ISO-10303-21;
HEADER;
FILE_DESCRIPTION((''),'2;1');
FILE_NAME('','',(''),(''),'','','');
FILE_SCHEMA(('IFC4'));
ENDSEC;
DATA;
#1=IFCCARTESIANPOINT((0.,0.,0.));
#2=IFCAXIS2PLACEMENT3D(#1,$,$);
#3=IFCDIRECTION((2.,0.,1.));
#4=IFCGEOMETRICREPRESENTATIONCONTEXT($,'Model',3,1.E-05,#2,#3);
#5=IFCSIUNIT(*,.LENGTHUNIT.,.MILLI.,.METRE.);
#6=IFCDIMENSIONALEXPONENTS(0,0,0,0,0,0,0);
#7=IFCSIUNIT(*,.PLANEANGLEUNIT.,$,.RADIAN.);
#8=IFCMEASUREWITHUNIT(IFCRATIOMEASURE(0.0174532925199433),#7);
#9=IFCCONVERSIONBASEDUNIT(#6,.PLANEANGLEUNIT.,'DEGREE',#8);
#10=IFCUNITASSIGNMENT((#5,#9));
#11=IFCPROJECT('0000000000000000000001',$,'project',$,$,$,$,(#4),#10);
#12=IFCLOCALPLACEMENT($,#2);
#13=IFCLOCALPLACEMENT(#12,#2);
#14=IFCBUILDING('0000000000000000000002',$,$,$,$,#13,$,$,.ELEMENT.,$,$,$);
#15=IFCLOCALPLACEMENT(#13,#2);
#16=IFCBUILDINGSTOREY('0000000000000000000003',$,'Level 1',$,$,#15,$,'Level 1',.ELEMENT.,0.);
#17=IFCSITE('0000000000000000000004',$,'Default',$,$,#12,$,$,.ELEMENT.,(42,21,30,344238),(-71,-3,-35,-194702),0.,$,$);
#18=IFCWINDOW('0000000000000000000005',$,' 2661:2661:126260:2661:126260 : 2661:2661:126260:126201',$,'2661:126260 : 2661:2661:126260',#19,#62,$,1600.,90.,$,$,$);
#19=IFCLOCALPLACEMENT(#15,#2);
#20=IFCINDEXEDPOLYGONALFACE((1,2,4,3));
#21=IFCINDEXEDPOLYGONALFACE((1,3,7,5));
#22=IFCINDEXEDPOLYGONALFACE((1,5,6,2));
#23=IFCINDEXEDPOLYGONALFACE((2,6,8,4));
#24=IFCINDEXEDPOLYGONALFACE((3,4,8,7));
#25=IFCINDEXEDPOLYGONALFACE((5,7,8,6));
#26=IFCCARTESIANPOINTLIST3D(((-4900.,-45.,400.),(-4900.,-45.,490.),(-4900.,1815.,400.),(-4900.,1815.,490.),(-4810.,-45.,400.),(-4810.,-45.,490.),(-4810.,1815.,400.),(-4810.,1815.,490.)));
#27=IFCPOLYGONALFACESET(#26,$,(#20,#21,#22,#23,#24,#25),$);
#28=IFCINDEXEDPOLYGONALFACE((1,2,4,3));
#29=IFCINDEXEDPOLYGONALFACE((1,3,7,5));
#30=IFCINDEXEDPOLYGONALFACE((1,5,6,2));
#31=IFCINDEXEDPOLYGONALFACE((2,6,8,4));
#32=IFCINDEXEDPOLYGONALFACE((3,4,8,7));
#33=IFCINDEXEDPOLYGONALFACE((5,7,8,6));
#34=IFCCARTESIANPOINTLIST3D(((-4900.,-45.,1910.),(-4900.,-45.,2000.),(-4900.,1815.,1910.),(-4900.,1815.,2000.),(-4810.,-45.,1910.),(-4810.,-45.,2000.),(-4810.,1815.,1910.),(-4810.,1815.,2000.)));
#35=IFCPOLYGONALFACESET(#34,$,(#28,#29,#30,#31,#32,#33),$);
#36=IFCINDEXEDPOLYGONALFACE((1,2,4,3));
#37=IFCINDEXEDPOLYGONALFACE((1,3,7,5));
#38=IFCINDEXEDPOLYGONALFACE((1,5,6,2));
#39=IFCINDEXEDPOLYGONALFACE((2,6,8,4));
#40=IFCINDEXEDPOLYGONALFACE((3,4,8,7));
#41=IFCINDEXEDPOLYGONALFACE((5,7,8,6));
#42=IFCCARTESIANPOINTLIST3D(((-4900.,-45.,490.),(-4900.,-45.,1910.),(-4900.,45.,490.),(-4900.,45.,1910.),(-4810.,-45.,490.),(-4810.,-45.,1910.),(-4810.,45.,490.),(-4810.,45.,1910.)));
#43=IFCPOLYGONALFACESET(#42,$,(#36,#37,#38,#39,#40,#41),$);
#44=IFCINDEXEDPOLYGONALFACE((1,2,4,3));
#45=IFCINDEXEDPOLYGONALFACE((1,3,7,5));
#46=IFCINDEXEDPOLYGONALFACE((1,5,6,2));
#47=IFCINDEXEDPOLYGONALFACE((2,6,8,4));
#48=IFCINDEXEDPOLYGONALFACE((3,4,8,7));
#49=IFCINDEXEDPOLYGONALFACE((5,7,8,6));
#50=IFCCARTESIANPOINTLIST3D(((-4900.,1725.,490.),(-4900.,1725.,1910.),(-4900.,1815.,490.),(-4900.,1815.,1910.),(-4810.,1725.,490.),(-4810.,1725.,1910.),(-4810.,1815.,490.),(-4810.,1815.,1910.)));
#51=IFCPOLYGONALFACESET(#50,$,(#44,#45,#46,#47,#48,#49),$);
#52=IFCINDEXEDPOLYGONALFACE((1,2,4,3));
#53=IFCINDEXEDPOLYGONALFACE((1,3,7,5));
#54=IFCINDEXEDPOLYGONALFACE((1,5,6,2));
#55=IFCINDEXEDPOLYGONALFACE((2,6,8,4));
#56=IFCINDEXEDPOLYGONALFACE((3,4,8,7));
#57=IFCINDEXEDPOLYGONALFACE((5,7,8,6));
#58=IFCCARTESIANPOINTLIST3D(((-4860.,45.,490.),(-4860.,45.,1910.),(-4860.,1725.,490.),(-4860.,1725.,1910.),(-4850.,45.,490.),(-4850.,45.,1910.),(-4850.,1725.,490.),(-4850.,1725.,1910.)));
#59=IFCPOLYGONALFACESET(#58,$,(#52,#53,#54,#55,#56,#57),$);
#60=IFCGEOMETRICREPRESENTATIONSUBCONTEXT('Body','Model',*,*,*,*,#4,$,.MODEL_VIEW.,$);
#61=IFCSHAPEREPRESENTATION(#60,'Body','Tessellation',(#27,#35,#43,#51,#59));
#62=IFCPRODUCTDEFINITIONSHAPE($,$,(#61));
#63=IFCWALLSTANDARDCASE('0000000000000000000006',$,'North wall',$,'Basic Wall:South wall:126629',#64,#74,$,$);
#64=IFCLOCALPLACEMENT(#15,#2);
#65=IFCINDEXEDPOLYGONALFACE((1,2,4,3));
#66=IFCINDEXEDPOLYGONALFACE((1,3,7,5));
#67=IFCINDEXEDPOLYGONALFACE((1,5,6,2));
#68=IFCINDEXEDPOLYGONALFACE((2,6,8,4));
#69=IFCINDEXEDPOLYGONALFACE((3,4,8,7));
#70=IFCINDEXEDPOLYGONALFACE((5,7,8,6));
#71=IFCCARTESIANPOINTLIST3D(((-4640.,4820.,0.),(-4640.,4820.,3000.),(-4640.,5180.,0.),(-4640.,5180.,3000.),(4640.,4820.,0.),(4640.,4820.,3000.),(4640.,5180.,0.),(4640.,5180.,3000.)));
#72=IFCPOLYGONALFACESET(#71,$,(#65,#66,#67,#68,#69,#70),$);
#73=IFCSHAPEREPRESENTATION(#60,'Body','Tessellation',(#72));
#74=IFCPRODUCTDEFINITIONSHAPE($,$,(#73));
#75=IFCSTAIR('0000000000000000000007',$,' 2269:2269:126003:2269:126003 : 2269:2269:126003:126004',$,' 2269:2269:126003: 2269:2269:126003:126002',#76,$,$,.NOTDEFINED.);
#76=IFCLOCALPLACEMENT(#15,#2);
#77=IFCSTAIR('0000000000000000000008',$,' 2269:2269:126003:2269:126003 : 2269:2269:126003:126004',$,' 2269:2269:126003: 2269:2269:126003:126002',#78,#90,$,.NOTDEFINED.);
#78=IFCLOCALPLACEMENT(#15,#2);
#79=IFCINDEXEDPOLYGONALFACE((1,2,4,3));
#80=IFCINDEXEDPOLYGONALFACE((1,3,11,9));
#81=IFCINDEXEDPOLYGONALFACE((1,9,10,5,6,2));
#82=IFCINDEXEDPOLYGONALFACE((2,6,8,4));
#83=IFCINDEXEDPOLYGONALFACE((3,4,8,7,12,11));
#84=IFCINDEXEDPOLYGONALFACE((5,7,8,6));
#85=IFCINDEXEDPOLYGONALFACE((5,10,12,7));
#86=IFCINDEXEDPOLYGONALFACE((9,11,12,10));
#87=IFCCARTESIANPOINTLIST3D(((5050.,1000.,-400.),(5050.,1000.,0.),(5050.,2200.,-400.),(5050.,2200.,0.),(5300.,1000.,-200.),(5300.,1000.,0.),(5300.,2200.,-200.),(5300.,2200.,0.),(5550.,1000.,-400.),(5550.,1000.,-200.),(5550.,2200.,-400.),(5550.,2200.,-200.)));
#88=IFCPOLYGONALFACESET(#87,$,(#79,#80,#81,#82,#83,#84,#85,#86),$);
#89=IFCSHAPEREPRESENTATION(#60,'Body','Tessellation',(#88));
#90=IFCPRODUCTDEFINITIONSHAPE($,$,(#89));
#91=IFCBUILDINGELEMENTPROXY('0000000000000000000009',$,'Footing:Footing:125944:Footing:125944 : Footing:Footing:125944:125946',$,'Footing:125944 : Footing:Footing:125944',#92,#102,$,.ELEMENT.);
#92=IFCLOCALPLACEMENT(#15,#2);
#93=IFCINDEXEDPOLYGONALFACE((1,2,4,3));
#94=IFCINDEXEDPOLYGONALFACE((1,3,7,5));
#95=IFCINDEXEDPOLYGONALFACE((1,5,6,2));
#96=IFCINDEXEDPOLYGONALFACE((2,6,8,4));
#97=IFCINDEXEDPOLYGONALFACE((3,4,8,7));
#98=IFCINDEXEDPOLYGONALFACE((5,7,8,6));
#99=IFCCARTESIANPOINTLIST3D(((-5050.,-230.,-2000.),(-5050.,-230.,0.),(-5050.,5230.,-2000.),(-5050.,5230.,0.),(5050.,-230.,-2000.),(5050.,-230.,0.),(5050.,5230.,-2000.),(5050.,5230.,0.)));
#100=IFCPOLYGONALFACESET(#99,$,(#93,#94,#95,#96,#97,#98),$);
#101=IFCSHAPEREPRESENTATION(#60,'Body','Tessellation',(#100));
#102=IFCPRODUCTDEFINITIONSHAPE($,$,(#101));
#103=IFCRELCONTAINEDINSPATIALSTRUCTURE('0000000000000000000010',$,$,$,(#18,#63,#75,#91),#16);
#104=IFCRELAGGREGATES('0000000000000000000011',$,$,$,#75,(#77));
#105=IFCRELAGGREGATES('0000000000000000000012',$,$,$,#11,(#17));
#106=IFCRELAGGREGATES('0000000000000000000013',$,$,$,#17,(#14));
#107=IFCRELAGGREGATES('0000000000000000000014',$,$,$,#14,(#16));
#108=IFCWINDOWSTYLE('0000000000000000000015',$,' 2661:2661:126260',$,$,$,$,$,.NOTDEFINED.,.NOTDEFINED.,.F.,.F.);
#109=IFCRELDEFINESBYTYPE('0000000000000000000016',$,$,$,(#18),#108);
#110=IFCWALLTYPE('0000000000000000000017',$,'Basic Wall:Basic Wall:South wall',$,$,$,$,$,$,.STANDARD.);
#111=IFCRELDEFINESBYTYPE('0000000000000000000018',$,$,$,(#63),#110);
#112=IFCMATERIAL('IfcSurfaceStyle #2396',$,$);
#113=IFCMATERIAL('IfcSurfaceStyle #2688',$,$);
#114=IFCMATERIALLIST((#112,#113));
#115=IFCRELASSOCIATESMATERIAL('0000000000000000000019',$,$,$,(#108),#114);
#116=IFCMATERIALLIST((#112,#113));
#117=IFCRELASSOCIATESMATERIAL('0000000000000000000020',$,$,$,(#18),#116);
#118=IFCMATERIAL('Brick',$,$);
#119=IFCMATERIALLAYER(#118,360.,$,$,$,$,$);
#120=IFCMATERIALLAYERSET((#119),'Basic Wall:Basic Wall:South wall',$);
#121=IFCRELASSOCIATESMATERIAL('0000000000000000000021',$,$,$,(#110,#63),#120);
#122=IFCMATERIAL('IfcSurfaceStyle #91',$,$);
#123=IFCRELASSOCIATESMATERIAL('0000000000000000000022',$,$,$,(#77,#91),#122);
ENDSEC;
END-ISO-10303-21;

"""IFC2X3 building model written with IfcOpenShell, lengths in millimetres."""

from ifc_helpers import new_model, entity, si_unit, converted_unit, direction, frame, frame_2d, origin, origin_2d_with_axis, place, context, subcontext, project, spatial, polyline, rectangle, outline, extrude, source, transform, mapped, material, material_list, layer, layer_set, layer_usage, type_object, type_shapes, element, aggregate, save


model = new_model("IFC2X3")

# Units and contexts
model_context = context("Model", 3, precision=1e-05, world=origin(), true_north=direction((2.0, 0.0, 1.0)))
body_context = subcontext(model_context, "Body", "Model", "MODEL_VIEW")
ifc_project = project(units=[si_unit("LENGTHUNIT", "METRE", prefix="MILLI"), converted_unit("PLANEANGLEUNIT", "DEGREE", entity("IfcRatioMeasure", 0.0174532925199433), si_unit("PLANEANGLEUNIT", "RADIAN"), dimensions=[0, 0, 0, 0, 0, 0, 0])], contexts=[model_context])

# Site, building, storey
site_placement = place(None, origin())
site = spatial("IfcSite", under=ifc_project, at=site_placement, Name="Default", CompositionType="ELEMENT", RefLatitude=(42, 21, 30, 344238), RefLongitude=(-71, -3, -35, -194702), RefElevation=0.0)
building_placement = place(site_placement, origin())
building = spatial("IfcBuilding", under=site, at=building_placement, CompositionType="ELEMENT")
storey_placement = place(building_placement, origin())
storey = spatial("IfcBuildingStorey", under=building, at=storey_placement, Name="Level 1", LongName="Level 1", CompositionType="ELEMENT", Elevation=0.0)

# Window
ifc_material_1 = material(Name="IfcSurfaceStyle #2396")
ifc_material_2 = material(Name="IfcSurfaceStyle #2688")
ifc_material_list_1 = material_list([ifc_material_1, ifc_material_2])
ifc_material_list_2 = material_list([ifc_material_1, ifc_material_2])
window_style_1 = type_object("IfcWindowStyle", Name=" 2661:2661:126260", ConstructionType="NOTDEFINED", OperationType="NOTDEFINED", ParameterTakesPrecedence=False, Sizeable=False, material=ifc_material_list_2)
shared_shape_1 = source(origin(), body_context, "Body", "SweptSolid", [
    extrude(rectangle(XDim=1860.0, YDim=90.0, at=origin_2d_with_axis()), frame((-4855.0, 885.0, 400.0), z_axis=(0.0, 0.0, 1.0), x_axis=(0.0, -1.0, 0.0)), (0.0, 0.0, 1.0), 90.0),
    extrude(rectangle(XDim=1860.0, YDim=90.0, at=origin_2d_with_axis()), frame((-4855.0, 885.0, 1910.0), z_axis=(0.0, 0.0, 1.0), x_axis=(0.0, -1.0, 0.0)), (0.0, 0.0, 1.0), 90.0),
    extrude(rectangle(XDim=90.0, YDim=90.0, at=origin_2d_with_axis()), frame((-4855.0, 0.0, 490.0), z_axis=(0.0, 0.0, 1.0), x_axis=(0.0, -1.0, 0.0)), (0.0, 0.0, 1.0), 1420.0),
    extrude(rectangle(XDim=90.0, YDim=90.0, at=frame_2d((0.0, 0.0), x_axis=(1.0, 0.0))), frame((-4855.0, 1770.0, 490.0), z_axis=(0.0, 0.0, 1.0), x_axis=(0.0, -1.0, 0.0)), (0.0, 0.0, 1.0), 1420.0),
    extrude(rectangle(XDim=1680.0, YDim=10.0, at=origin_2d_with_axis()), frame((-4855.0, 885.0, 490.0), z_axis=(0.0, 0.0, 1.0), x_axis=(0.0, -1.0, 0.0)), (0.0, 0.0, 1.0), 1420.0),
])
type_shapes(window_style_1, [shared_shape_1])
window_1_placement = place(storey_placement, origin())
element("IfcWindow", 1, at=window_1_placement, inside=storey, type_object=window_style_1, material=ifc_material_list_1, Name=" 2661:2661:126260:2661:126260 : 2661:2661:126260:126201", ObjectType="2661:126260 : 2661:2661:126260", OverallHeight=1600.0, OverallWidth=90.0, context=body_context, shape_type="MappedRepresentation", body=[
    mapped(shared_shape_1, transform((0.0, 0.0, 0.0), scale=1.0)),
])

# Shared definitions
ifc_material_3 = material(Name="Brick")
ifc_layer = layer(ifc_material_3, 360.0)
ifc_layer_set = layer_set([ifc_layer], Name="Basic Wall:Basic Wall:South wall")
wall_type = type_object("IfcWallType", Name="Basic Wall:Basic Wall:South wall", PredefinedType="STANDARD", material=ifc_layer_set)

# Wall
ifc_layer_usage_1 = layer_usage(ifc_layer_set, "AXIS2", "NEGATIVE", 180.0)
wall_1_placement = place(storey_placement, frame((4640.0, 5000.0, 0.0), z_axis=(0.0, 0.0, 1.0), x_axis=(-1.0, 0.0, 0.0)))
element("IfcWallStandardCase", 2, at=wall_1_placement, inside=storey, type_object=wall_type, material=ifc_layer_usage_1, Name="North wall", ObjectType="Basic Wall:South wall:126629", context=body_context, shape_type="SweptSolid", body=[
    extrude(rectangle(XDim=9280.0, YDim=360.0, at=frame_2d((4640.0, 0.0), x_axis=(-1.0, 0.0))), origin(), (0.0, 0.0, 1.0), 3000.0),
])

# Stairs
stair_1_placement = place(storey_placement, frame((5050.0, 1000.0, -400.0)))
stair_1 = element("IfcStair", 3, at=stair_1_placement, inside=storey, Name=" 2269:2269:126003:2269:126003 : 2269:2269:126003:126004", ObjectType=" 2269:2269:126003: 2269:2269:126003:126002", ShapeType="NOTDEFINED")
ifc_material_4 = material(Name="IfcSurfaceStyle #91")
stair_2_placement = place(stair_1_placement, origin())
stair_2 = element("IfcStair", 4, at=stair_2_placement, material=ifc_material_4, Name=" 2269:2269:126003:2269:126003 : 2269:2269:126003:126004", ObjectType=" 2269:2269:126003: 2269:2269:126003:126002", ShapeType="NOTDEFINED", context=body_context, shape_type="SweptSolid", body=[
    extrude(outline(polyline([(0.0, 0.0), (250.0, 0.0), (250.0, 200.0), (-250.0, 200.0), (-250.0, -200.0), (0.0, -200.0), (0.0, 0.0)])), frame((250.0, 0.0, 200.0), z_axis=(0.0, 1.0, 0.0), x_axis=(1.0, 0.0, 0.0)), (0.0, 0.0, 1.0), 1200.0),
])
aggregate(stair_1, [stair_2])

# Building element proxy
shared_shape_2 = source(origin(), body_context, "Body", "SweptSolid", [
    extrude(rectangle(XDim=10100.0, YDim=5460.0, at=origin_2d_with_axis()), frame((0.0, 2500.0, -2000.0), z_axis=(0.0, 0.0, 1.0), x_axis=(-1.0, 0.0, 0.0)), (0.0, 0.0, 1.0), 2000.0),
])
proxy_placement = place(storey_placement, origin())
element("IfcBuildingElementProxy", 5, at=proxy_placement, inside=storey, material=ifc_material_4, Name="Footing:Footing:125944:Footing:125944 : Footing:Footing:125944:125946", ObjectType="Footing:125944 : Footing:Footing:125944", CompositionType="ELEMENT", context=body_context, shape_type="MappedRepresentation", body=[
    mapped(shared_shape_2, transform((0.0, 0.0, 0.0), scale=1.0)),
])

save(model, "model.ifc")
